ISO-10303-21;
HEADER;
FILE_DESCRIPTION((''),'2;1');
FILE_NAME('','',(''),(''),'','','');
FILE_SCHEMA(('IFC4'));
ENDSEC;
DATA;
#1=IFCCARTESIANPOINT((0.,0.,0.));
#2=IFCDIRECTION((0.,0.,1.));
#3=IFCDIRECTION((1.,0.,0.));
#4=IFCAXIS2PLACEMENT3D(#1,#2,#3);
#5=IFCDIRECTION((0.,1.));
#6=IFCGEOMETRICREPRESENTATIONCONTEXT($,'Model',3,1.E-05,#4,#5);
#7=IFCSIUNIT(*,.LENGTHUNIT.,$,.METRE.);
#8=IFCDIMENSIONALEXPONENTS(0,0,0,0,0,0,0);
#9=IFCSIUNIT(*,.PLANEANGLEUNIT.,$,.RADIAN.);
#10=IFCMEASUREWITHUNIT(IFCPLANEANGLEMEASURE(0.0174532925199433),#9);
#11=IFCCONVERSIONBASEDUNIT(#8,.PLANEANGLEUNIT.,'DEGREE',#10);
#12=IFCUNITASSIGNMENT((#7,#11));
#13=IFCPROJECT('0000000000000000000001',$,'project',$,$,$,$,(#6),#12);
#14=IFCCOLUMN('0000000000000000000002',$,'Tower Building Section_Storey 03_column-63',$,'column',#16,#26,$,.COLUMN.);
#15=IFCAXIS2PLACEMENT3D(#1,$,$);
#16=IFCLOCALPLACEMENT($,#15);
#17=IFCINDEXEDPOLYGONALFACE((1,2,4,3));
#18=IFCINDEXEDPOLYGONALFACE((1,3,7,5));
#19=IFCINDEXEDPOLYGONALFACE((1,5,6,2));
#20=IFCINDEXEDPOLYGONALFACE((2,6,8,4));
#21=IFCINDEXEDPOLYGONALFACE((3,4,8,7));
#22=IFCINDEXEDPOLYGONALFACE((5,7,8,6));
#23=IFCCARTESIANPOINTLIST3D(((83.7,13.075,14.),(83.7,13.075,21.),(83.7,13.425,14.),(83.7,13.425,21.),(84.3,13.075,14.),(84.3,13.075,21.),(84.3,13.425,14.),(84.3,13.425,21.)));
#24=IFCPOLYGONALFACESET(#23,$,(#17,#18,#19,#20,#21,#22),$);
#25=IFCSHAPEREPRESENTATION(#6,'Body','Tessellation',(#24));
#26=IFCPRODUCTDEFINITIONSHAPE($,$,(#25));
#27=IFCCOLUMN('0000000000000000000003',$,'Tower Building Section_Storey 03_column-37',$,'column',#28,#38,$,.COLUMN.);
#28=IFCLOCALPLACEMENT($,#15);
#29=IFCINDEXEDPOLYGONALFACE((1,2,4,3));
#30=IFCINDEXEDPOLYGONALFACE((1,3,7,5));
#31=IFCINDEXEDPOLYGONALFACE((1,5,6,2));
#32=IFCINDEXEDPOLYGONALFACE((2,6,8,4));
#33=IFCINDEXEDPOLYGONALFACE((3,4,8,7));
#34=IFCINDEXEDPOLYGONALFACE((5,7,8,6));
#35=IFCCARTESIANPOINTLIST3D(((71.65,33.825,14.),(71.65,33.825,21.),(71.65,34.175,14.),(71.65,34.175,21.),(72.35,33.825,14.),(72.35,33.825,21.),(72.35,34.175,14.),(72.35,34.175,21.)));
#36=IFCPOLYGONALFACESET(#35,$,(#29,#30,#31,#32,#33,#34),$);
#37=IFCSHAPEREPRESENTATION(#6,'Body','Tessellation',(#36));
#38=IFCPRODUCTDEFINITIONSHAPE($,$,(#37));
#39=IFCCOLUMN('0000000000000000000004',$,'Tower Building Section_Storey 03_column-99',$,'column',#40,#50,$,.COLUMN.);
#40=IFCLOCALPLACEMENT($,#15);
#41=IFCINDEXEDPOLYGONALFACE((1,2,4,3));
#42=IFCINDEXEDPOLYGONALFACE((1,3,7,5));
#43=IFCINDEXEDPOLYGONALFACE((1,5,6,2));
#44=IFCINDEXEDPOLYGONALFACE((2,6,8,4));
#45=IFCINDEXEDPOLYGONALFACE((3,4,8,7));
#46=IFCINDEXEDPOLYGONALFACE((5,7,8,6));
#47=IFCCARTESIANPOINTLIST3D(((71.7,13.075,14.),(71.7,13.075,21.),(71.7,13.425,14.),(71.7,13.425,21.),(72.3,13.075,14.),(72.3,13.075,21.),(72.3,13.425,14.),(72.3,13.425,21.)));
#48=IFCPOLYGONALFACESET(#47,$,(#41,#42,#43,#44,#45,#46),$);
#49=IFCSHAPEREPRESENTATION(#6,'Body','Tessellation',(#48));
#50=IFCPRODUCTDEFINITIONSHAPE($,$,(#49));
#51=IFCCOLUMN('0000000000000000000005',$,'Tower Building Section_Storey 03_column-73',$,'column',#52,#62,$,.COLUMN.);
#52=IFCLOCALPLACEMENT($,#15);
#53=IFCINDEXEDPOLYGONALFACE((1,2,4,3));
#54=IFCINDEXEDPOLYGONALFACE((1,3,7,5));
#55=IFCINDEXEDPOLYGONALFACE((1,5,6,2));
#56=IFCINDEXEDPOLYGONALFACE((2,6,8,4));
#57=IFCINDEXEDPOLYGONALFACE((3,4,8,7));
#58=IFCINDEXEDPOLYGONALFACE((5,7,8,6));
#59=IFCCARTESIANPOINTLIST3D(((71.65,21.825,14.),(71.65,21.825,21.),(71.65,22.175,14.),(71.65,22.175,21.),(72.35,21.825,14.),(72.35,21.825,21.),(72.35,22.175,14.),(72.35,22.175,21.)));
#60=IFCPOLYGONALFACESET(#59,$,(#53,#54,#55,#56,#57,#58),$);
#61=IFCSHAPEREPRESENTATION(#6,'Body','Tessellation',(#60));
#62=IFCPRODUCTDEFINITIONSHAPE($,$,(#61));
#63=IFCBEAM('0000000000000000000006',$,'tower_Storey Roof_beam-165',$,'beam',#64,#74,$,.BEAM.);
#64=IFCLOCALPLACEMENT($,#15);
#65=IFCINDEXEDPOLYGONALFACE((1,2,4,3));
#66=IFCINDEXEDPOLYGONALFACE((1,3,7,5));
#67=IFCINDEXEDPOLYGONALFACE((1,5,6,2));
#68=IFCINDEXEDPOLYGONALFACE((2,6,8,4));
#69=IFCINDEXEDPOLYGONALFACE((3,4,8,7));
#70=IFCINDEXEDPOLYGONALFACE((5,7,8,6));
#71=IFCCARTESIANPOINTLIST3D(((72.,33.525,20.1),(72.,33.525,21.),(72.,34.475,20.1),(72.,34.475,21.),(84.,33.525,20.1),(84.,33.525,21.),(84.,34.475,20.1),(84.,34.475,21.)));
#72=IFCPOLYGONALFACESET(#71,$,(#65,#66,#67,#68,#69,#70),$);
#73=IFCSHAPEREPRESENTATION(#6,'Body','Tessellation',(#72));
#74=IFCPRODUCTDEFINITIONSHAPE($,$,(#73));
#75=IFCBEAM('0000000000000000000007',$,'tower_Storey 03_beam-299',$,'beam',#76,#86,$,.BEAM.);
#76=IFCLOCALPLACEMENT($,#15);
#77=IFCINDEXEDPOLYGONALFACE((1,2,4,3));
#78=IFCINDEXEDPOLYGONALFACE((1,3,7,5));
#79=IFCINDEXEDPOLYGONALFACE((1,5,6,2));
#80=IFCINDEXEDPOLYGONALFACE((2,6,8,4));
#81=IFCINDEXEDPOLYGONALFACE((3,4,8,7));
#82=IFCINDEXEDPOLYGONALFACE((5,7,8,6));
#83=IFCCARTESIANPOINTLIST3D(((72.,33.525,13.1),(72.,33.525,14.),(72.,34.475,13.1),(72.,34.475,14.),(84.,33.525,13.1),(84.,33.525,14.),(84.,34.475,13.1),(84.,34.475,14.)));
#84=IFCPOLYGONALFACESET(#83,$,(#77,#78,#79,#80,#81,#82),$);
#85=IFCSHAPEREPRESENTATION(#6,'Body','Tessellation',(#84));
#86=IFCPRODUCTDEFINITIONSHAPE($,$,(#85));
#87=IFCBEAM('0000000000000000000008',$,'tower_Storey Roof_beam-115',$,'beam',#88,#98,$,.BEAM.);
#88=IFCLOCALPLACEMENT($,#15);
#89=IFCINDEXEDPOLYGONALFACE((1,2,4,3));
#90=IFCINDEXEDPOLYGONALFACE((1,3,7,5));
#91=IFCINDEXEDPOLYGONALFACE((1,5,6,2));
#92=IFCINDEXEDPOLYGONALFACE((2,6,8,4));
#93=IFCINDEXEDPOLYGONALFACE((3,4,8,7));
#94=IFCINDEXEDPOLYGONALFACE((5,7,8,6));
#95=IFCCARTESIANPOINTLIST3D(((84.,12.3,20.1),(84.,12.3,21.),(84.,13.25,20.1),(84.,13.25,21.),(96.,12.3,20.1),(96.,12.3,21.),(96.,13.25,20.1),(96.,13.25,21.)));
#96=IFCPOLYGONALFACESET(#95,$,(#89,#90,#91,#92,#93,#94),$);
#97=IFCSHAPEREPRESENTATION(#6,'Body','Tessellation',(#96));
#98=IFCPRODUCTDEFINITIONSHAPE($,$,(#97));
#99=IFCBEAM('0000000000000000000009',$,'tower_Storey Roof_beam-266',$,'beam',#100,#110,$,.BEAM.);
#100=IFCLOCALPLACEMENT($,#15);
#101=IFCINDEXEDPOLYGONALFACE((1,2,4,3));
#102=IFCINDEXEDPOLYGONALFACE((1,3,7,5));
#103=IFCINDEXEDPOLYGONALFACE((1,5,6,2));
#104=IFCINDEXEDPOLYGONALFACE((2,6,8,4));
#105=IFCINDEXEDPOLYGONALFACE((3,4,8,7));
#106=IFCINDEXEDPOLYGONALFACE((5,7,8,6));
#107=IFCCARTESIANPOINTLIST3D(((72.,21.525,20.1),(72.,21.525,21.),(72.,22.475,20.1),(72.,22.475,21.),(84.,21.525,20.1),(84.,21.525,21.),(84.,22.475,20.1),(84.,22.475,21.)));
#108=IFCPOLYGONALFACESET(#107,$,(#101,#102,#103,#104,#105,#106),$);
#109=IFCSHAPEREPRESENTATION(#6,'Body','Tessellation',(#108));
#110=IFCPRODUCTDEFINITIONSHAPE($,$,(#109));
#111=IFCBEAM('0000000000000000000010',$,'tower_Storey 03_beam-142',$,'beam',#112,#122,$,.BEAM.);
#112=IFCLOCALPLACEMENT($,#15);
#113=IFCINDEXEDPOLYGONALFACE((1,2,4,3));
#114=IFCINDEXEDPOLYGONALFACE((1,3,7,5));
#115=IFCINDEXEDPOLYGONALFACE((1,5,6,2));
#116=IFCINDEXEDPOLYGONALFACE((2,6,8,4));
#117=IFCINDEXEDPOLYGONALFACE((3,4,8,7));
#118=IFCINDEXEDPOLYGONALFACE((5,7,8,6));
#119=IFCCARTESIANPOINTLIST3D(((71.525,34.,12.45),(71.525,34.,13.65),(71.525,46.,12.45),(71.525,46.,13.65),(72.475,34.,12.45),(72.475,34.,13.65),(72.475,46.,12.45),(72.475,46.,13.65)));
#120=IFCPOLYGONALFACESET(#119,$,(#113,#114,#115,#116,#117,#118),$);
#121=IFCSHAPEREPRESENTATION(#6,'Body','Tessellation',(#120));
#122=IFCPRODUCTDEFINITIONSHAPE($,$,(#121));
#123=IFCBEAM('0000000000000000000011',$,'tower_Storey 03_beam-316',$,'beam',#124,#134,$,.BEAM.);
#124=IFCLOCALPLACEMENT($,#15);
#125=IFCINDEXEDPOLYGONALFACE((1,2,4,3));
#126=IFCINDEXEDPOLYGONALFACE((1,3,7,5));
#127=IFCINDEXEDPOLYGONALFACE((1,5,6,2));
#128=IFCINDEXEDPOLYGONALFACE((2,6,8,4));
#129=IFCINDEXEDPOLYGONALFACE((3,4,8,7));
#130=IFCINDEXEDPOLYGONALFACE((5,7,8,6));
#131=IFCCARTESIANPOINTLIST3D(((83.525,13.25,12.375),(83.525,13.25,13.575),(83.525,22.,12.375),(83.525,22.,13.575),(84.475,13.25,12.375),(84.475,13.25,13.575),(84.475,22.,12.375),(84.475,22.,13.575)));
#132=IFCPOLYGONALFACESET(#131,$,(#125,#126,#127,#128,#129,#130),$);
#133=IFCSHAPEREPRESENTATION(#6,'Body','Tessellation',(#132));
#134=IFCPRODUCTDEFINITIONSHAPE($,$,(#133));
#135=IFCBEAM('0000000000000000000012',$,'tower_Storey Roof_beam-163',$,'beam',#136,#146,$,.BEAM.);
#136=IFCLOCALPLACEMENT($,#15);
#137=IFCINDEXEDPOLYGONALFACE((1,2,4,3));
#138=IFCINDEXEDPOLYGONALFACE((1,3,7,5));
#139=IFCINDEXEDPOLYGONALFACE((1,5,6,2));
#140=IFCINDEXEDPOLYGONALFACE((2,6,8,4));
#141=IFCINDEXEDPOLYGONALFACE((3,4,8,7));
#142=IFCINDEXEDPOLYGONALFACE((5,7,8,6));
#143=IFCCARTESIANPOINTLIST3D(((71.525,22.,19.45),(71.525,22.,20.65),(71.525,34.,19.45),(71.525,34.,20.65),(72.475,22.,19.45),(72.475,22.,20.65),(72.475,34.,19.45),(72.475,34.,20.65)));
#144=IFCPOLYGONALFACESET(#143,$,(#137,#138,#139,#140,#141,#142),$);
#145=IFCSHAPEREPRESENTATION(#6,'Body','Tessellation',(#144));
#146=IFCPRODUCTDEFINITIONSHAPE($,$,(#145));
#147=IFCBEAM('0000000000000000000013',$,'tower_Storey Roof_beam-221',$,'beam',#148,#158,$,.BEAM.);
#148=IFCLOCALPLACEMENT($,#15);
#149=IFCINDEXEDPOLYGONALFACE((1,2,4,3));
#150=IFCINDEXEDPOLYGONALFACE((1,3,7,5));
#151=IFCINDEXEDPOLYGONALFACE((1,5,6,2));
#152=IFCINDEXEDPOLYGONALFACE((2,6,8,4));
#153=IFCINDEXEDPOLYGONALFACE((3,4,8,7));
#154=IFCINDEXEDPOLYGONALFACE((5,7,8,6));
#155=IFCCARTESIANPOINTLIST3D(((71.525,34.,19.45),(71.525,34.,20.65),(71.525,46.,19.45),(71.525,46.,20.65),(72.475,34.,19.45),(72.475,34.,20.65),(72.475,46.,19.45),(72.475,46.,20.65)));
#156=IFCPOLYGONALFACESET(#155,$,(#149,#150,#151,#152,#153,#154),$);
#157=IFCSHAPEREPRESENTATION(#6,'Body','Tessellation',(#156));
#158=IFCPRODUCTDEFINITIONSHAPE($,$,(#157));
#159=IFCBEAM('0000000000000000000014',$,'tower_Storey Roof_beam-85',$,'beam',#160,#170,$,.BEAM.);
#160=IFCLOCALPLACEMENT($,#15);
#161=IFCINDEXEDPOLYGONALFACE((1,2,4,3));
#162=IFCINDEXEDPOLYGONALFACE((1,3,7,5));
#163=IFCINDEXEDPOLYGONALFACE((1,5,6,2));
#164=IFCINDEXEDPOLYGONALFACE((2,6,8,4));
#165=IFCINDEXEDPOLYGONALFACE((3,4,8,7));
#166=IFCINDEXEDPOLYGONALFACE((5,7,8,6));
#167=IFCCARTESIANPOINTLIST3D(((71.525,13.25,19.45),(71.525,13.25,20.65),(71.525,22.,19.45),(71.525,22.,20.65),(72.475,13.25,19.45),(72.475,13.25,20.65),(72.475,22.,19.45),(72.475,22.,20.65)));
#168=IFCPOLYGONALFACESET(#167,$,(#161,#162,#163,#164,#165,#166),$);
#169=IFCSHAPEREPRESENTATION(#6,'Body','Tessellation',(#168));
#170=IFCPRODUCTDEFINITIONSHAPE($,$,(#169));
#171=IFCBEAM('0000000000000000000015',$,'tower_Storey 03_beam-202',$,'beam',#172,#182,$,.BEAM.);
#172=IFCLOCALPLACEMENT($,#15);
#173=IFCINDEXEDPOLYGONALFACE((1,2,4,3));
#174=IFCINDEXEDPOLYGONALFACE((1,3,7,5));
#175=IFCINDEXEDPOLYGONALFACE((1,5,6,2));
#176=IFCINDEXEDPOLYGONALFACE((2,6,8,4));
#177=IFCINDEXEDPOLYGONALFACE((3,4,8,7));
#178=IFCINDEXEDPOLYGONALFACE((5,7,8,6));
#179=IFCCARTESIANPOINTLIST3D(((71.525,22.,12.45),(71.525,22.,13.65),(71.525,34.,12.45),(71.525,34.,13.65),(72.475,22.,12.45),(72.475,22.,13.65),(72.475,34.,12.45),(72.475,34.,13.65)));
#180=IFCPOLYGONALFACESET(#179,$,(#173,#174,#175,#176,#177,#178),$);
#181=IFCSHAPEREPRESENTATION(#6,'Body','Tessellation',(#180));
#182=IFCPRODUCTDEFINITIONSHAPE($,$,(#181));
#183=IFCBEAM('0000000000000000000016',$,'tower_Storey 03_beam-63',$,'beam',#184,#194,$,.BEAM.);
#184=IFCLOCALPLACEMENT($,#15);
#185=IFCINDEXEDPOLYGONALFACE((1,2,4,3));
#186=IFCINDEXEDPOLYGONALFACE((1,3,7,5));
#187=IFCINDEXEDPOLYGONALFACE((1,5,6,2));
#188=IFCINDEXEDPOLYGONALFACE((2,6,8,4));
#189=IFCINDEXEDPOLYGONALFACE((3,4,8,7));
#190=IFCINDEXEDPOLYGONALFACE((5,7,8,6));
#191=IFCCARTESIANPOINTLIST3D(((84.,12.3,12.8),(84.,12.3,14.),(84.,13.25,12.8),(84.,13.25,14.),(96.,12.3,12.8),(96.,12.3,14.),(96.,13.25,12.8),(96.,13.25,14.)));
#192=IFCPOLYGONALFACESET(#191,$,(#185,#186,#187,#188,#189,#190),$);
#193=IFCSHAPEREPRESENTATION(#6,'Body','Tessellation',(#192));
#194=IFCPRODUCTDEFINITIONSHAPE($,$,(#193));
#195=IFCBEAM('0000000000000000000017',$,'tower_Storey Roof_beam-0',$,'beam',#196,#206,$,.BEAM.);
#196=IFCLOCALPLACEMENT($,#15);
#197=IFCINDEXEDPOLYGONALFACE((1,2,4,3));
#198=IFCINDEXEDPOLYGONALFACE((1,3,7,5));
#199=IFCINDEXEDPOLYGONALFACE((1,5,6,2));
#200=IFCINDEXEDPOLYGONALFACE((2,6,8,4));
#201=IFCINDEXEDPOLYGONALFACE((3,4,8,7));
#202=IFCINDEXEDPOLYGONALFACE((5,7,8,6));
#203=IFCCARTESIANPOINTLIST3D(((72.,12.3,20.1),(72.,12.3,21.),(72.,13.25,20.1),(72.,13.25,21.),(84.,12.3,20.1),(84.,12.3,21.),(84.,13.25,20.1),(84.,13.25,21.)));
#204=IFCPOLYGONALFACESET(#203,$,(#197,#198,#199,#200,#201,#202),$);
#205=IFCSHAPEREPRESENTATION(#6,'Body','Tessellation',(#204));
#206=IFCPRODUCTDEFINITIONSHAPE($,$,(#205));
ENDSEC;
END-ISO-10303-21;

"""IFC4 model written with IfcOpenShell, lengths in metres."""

from ifc_helpers import new_model, entity, si_unit, converted_unit, direction, frame, origin_with_axes, place, context, project, polyline, outline, extrude, element, save


model = new_model("IFC4")

# Units and contexts
model_context = context("Model", 3, precision=1e-05, world=origin_with_axes(), true_north=direction((0.0, 1.0)))
ifc_project = project(units=[si_unit("LENGTHUNIT", "METRE"), converted_unit("PLANEANGLEUNIT", "DEGREE", entity("IfcPlaneAngleMeasure", 0.0174532925199433), si_unit("PLANEANGLEUNIT", "RADIAN"), dimensions=[0, 0, 0, 0, 0, 0, 0])], contexts=[model_context])

# Columns
placement_1 = place(None, origin_with_axes())
placement_2 = place(placement_1, frame((0.0, 0.0, 14.0), z_axis=(0.0, 0.0, 1.0), x_axis=(1.0, 0.0, 0.0)))
column_1_placement = place(placement_2, frame((84.0, 13.25, 0.0), z_axis=(0.0, 0.0, 1.0), x_axis=(1.0, 0.0, 0.0)))
element("IfcColumn", 1, at=column_1_placement, Name="Tower Building Section_Storey 03_column-63", ObjectType="column", PredefinedType="COLUMN", context=model_context, body=[
    extrude(outline(polyline([(-0.3, -0.175, 0.0), (0.3, -0.175, 0.0), (0.3, 0.175, 0.0), (-0.3, 0.175, 0.0), (-0.3, -0.175, 0.0)])), origin_with_axes(), (0.0, 0.0, 1.0), 7.0),
])
column_2_placement = place(placement_2, frame((72.0, 34.0, 0.0), z_axis=(0.0, 0.0, 1.0), x_axis=(1.0, 0.0, 0.0)))
element("IfcColumn", 2, at=column_2_placement, Name="Tower Building Section_Storey 03_column-37", ObjectType="column", PredefinedType="COLUMN", context=model_context, body=[
    extrude(outline(polyline([(-0.35, -0.175, 0.0), (0.35, -0.175, 0.0), (0.35, 0.175, 0.0), (-0.35, 0.175, 0.0), (-0.35, -0.175, 0.0)])), origin_with_axes(), (0.0, 0.0, 1.0), 7.0),
])
column_3_placement = place(placement_2, frame((72.0, 13.25, 0.0), z_axis=(0.0, 0.0, 1.0), x_axis=(1.0, 0.0, 0.0)))
element("IfcColumn", 3, at=column_3_placement, Name="Tower Building Section_Storey 03_column-99", ObjectType="column", PredefinedType="COLUMN", context=model_context, body=[
    extrude(outline(polyline([(-0.3, -0.175, 0.0), (0.3, -0.175, 0.0), (0.3, 0.175, 0.0), (-0.3, 0.175, 0.0), (-0.3, -0.175, 0.0)])), origin_with_axes(), (0.0, 0.0, 1.0), 7.0),
])
column_4_placement = place(placement_2, frame((72.0, 22.0, 0.0), z_axis=(0.0, 0.0, 1.0), x_axis=(1.0, 0.0, 0.0)))
element("IfcColumn", 4, at=column_4_placement, Name="Tower Building Section_Storey 03_column-73", ObjectType="column", PredefinedType="COLUMN", context=model_context, body=[
    extrude(outline(polyline([(-0.35, -0.175, 0.0), (0.35, -0.175, 0.0), (0.35, 0.175, 0.0), (-0.35, 0.175, 0.0), (-0.35, -0.175, 0.0)])), origin_with_axes(), (0.0, 0.0, 1.0), 7.0),
])

# Beams
placement_3 = place(placement_1, frame((0.0, 0.0, 21.0), z_axis=(0.0, 0.0, 1.0), x_axis=(1.0, 0.0, 0.0)))
beam_1_placement = place(placement_3, frame((72.0, 34.0, -0.45), z_axis=(1.0, 0.0, 0.0), x_axis=(0.0, 1.0, 0.0)))
element("IfcBeam", 5, at=beam_1_placement, Name="tower_Storey Roof_beam-165", ObjectType="beam", PredefinedType="BEAM", context=model_context, body=[
    extrude(outline(polyline([(0.475, 0.45, 0.0), (-0.475, 0.45, 0.0), (-0.475, -0.45, 0.0), (0.475, -0.45, 0.0), (0.475, 0.45, 0.0)])), origin_with_axes(), (0.0, 0.0, 1.0), 12.0),
])
beam_2_placement = place(placement_2, frame((72.0, 34.0, -0.45), z_axis=(1.0, 0.0, 0.0), x_axis=(0.0, 1.0, 0.0)))
element("IfcBeam", 6, at=beam_2_placement, Name="tower_Storey 03_beam-299", ObjectType="beam", PredefinedType="BEAM", context=model_context, body=[
    extrude(outline(polyline([(0.475, 0.45, 0.0), (-0.475, 0.45, 0.0), (-0.475, -0.45, 0.0), (0.475, -0.45, 0.0), (0.475, 0.45, 0.0)])), origin_with_axes(), (0.0, 0.0, 1.0), 12.0),
])
for number, where, z_axis, x_axis, name in (
    (7, (84.0, 12.775, -0.45), (1.0, 0.0, 0.0), (0.0, 1.0, 0.0), "tower_Storey Roof_beam-115"),
    (8, (72.0, 22.0, -0.45), (1.0, 0.0, 0.0), (0.0, 1.0, 0.0), "tower_Storey Roof_beam-266"),
):
    element("IfcBeam", number, at=place(placement_3, frame(where, z_axis=z_axis, x_axis=x_axis)), Name=name, ObjectType="beam", PredefinedType="BEAM", context=model_context, body=[
        extrude(outline(polyline([(0.475, 0.45, 0.0), (-0.475, 0.45, 0.0), (-0.475, -0.45, 0.0), (0.475, -0.45, 0.0), (0.475, 0.45, 0.0)])), origin_with_axes(), (0.0, 0.0, 1.0), 12.0),
    ])
beam_3_placement = place(placement_2, frame((72.0, 34.0, -0.95), z_axis=(0.0, 1.0, 0.0), x_axis=(-1.0, 0.0, 0.0)))
element("IfcBeam", 9, at=beam_3_placement, Name="tower_Storey 03_beam-142", ObjectType="beam", PredefinedType="BEAM", context=model_context, body=[
    extrude(outline(polyline([(0.475, 0.6, 0.0), (-0.475, 0.6, 0.0), (-0.475, -0.6, 0.0), (0.475, -0.6, 0.0), (0.475, 0.6, 0.0)])), origin_with_axes(), (0.0, 0.0, 1.0), 12.0),
])
beam_4_placement = place(placement_2, frame((84.0, 13.25, -1.025), z_axis=(0.0, 1.0, 0.0), x_axis=(-1.0, 0.0, 0.0)))
element("IfcBeam", 10, at=beam_4_placement, Name="tower_Storey 03_beam-316", ObjectType="beam", PredefinedType="BEAM", context=model_context, body=[
    extrude(outline(polyline([(0.475, 0.6, 0.0), (-0.475, 0.6, 0.0), (-0.475, -0.6, 0.0), (0.475, -0.6, 0.0), (0.475, 0.6, 0.0)])), origin_with_axes(), (0.0, 0.0, 1.0), 8.75),
])
for number, where, z_axis, x_axis, name in (
    (11, (72.0, 22.0, -0.95), (0.0, 1.0, 0.0), (-1.0, 0.0, 0.0), "tower_Storey Roof_beam-163"),
    (12, (72.0, 34.0, -0.95), (0.0, 1.0, 0.0), (-1.0, 0.0, 0.0), "tower_Storey Roof_beam-221"),
):
    element("IfcBeam", number, at=place(placement_3, frame(where, z_axis=z_axis, x_axis=x_axis)), Name=name, ObjectType="beam", PredefinedType="BEAM", context=model_context, body=[
        extrude(outline(polyline([(0.475, 0.6, 0.0), (-0.475, 0.6, 0.0), (-0.475, -0.6, 0.0), (0.475, -0.6, 0.0), (0.475, 0.6, 0.0)])), origin_with_axes(), (0.0, 0.0, 1.0), 12.0),
    ])
beam_5_placement = place(placement_3, frame((72.0, 13.25, -0.95), z_axis=(0.0, 1.0, 0.0), x_axis=(-1.0, 0.0, 0.0)))
element("IfcBeam", 13, at=beam_5_placement, Name="tower_Storey Roof_beam-85", ObjectType="beam", PredefinedType="BEAM", context=model_context, body=[
    extrude(outline(polyline([(0.475, 0.6, 0.0), (-0.475, 0.6, 0.0), (-0.475, -0.6, 0.0), (0.475, -0.6, 0.0), (0.475, 0.6, 0.0)])), origin_with_axes(), (0.0, 0.0, 1.0), 8.75),
])
for number, where, z_axis, x_axis, name in (
    (14, (72.0, 22.0, -0.95), (0.0, 1.0, 0.0), (-1.0, 0.0, 0.0), "tower_Storey 03_beam-202"),
    (15, (84.0, 12.775, -0.6), (1.0, 0.0, 0.0), (0.0, 1.0, 0.0), "tower_Storey 03_beam-63"),
):
    element("IfcBeam", number, at=place(placement_2, frame(where, z_axis=z_axis, x_axis=x_axis)), Name=name, ObjectType="beam", PredefinedType="BEAM", context=model_context, body=[
        extrude(outline(polyline([(0.475, 0.6, 0.0), (-0.475, 0.6, 0.0), (-0.475, -0.6, 0.0), (0.475, -0.6, 0.0), (0.475, 0.6, 0.0)])), origin_with_axes(), (0.0, 0.0, 1.0), 12.0),
    ])
beam_6_placement = place(placement_3, frame((72.0, 12.775, -0.45), z_axis=(1.0, 0.0, 0.0), x_axis=(0.0, 1.0, 0.0)))
element("IfcBeam", 16, at=beam_6_placement, Name="tower_Storey Roof_beam-0", ObjectType="beam", PredefinedType="BEAM", context=model_context, body=[
    extrude(outline(polyline([(0.475, 0.45, 0.0), (-0.475, 0.45, 0.0), (-0.475, -0.45, 0.0), (0.475, -0.45, 0.0), (0.475, 0.45, 0.0)])), origin_with_axes(), (0.0, 0.0, 1.0), 12.0),
])

save(model, "model.ifc")
